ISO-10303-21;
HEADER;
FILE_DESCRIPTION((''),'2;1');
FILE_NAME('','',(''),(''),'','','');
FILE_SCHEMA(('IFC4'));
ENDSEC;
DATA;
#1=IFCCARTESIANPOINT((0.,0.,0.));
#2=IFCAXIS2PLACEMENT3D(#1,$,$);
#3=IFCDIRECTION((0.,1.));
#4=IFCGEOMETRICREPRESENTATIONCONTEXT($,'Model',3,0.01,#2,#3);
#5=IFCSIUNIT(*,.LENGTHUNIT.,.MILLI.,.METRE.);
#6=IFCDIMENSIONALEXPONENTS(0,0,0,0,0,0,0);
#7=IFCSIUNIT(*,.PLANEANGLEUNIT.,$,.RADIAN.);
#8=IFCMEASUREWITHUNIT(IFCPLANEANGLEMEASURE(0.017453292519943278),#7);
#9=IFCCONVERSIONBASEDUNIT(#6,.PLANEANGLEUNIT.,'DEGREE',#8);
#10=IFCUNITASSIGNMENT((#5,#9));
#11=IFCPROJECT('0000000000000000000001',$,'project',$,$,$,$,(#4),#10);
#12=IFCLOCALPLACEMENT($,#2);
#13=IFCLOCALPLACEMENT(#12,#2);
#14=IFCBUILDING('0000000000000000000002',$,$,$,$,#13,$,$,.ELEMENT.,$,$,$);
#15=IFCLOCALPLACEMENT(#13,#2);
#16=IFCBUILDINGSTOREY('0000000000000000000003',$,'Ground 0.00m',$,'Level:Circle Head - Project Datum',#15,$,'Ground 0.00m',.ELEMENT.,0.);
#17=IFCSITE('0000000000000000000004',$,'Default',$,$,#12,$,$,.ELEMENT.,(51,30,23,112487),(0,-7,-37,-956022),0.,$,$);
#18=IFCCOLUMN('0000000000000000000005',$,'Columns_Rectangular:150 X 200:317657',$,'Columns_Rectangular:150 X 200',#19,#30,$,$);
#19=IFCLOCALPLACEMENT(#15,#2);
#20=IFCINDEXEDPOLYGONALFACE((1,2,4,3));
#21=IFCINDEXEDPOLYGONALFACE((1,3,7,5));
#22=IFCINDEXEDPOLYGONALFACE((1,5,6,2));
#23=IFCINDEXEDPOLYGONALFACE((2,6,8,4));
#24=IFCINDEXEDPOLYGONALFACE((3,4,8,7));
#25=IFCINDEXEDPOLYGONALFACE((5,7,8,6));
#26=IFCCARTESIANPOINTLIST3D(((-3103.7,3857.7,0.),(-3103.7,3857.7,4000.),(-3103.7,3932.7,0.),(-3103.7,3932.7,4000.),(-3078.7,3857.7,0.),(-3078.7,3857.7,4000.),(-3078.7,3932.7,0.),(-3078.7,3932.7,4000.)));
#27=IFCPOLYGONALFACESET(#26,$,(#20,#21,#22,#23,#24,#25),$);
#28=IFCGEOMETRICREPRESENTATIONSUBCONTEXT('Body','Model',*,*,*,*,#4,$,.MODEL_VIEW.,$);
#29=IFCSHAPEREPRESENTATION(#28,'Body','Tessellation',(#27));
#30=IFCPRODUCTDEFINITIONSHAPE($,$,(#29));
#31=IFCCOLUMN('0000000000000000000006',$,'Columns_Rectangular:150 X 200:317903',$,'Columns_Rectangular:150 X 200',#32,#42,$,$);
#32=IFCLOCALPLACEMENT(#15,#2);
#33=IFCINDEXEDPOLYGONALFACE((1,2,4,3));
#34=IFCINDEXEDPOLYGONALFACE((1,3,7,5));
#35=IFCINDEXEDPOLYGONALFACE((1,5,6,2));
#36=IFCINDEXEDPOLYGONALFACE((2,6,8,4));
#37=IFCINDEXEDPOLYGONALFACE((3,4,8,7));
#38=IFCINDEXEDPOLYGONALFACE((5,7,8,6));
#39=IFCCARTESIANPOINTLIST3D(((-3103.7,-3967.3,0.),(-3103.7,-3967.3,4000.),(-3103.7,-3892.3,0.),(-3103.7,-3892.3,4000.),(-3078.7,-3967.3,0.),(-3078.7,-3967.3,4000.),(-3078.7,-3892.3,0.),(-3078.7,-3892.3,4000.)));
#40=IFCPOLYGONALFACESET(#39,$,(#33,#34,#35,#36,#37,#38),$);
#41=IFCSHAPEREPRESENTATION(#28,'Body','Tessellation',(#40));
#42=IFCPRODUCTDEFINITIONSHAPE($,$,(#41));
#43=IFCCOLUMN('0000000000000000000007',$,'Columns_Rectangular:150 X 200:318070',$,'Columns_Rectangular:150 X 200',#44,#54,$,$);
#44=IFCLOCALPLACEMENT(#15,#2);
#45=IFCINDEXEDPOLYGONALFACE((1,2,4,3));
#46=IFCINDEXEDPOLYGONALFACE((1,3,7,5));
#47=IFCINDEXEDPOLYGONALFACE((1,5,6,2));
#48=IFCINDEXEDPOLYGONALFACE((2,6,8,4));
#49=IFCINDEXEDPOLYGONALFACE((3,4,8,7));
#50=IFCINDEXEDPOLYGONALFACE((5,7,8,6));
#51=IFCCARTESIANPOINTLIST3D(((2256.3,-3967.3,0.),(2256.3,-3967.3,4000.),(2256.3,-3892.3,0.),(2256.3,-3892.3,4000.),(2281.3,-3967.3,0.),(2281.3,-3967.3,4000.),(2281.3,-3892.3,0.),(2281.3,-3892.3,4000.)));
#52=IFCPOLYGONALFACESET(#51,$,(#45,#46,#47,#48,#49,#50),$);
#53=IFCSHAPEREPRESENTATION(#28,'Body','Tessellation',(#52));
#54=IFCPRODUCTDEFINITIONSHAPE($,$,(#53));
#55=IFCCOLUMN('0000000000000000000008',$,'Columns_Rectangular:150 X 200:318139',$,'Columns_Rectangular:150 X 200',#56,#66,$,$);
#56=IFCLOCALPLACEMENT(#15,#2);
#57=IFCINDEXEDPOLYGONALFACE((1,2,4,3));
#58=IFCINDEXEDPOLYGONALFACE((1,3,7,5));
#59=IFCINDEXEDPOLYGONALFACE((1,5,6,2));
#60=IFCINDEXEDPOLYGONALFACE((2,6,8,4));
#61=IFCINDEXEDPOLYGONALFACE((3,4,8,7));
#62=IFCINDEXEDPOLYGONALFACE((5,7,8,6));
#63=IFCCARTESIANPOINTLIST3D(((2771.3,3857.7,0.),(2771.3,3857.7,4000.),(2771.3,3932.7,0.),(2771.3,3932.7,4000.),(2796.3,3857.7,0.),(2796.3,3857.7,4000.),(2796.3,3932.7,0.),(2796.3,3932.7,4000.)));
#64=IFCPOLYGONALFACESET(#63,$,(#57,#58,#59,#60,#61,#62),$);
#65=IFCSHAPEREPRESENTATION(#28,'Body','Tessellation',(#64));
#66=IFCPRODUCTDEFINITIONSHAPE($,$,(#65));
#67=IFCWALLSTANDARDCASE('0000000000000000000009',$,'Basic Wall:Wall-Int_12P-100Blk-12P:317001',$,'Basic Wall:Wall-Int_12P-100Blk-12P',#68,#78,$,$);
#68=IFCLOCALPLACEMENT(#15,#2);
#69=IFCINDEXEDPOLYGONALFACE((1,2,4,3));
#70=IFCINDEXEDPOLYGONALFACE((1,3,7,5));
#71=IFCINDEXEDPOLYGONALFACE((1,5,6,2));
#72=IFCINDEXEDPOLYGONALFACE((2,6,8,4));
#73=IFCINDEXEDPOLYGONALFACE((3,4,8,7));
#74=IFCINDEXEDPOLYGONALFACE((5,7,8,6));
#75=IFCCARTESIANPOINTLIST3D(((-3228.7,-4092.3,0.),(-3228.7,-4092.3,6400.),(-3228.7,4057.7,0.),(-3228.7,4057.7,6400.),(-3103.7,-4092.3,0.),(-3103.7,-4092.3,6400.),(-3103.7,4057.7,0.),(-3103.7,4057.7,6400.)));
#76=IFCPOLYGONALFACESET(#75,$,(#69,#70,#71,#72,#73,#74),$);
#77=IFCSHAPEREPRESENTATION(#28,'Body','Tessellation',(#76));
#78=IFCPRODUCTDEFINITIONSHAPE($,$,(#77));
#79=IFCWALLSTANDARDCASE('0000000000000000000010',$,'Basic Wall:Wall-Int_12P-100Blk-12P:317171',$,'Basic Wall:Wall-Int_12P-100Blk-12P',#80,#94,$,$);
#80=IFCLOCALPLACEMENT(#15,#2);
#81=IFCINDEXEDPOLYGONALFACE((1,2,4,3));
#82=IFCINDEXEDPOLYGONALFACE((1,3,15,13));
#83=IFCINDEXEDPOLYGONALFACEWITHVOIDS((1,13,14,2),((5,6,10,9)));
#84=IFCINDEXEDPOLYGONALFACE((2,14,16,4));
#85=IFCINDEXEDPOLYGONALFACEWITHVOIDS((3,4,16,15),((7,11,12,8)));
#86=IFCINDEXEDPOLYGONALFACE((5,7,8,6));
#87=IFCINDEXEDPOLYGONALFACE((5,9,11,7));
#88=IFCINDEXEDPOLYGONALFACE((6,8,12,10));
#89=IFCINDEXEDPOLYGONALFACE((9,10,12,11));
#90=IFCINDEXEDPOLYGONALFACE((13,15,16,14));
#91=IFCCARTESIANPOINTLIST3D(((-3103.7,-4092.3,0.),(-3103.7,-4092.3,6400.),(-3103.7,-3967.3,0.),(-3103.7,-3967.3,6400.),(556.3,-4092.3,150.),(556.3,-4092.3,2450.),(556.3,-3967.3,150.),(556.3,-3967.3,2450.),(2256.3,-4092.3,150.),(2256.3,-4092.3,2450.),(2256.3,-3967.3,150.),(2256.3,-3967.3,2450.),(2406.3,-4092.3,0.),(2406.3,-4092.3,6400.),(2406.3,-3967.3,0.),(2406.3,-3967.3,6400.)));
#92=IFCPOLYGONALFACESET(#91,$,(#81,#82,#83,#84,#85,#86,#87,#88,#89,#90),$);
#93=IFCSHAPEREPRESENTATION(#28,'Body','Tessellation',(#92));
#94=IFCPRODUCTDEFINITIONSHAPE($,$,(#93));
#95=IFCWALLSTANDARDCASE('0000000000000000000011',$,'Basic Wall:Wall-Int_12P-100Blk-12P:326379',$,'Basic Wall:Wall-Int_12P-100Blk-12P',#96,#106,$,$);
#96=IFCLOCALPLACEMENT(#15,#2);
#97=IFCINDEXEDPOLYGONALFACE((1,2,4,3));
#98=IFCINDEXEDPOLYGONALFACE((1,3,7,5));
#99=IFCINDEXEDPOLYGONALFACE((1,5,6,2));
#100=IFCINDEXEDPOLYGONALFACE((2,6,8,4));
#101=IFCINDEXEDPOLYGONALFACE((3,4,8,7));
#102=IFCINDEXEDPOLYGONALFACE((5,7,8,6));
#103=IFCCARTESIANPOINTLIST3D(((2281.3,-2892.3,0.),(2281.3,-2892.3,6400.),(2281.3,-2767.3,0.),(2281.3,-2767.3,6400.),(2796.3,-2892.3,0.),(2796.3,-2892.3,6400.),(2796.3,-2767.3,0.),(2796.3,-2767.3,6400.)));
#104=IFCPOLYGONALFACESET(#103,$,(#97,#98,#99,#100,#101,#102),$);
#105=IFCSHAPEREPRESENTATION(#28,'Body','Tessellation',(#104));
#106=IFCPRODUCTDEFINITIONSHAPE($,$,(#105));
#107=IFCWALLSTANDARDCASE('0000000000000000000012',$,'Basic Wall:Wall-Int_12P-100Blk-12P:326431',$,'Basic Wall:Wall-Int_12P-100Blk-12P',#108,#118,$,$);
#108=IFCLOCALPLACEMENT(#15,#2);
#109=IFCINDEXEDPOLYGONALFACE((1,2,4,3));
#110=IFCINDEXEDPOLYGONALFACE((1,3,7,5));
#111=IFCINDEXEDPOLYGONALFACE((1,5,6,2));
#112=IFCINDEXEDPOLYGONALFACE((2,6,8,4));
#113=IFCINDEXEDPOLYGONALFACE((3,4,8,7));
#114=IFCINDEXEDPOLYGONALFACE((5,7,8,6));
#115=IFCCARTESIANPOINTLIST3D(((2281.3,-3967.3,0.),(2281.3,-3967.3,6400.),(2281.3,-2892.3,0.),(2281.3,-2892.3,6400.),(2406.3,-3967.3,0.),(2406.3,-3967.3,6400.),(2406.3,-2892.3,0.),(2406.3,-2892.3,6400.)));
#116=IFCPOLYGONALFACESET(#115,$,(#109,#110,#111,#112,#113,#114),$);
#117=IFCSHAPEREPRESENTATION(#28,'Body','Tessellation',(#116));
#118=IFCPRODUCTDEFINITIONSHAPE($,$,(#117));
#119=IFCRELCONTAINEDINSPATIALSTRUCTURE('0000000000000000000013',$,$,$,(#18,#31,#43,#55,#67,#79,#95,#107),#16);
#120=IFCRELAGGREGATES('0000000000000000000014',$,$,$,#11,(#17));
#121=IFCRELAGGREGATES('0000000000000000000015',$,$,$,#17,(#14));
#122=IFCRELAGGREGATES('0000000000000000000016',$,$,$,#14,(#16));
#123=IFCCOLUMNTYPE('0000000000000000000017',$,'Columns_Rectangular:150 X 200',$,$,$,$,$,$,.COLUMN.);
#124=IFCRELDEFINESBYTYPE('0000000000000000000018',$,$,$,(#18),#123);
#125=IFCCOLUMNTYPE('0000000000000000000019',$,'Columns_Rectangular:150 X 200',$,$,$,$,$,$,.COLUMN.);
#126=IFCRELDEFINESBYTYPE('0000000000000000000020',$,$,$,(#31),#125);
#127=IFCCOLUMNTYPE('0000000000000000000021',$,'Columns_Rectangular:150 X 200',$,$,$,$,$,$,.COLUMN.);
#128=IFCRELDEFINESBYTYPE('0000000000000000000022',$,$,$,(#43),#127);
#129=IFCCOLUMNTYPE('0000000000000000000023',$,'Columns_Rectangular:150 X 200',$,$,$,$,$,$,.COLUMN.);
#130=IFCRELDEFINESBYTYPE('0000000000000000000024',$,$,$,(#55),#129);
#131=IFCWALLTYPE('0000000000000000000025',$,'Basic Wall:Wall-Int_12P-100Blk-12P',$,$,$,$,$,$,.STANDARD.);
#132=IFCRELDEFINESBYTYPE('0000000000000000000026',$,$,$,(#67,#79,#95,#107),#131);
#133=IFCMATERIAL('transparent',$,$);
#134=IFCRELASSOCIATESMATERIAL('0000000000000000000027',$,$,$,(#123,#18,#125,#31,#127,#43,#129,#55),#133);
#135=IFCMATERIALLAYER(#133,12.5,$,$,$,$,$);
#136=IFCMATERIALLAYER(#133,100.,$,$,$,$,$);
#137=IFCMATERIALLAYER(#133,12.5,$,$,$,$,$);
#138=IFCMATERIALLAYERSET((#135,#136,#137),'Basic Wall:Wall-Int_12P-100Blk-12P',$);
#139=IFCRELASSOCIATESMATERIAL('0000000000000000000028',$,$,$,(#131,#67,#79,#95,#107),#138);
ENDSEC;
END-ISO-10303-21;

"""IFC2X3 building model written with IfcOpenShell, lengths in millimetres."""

from ifc_helpers import new_model, entity, si_unit, converted_unit, direction, frame, frame_2d, origin, place, context, subcontext, project, spatial, rectangle, extrude, source, transform, mapped, material, layer, layer_set, layer_usage, type_object, type_shapes, element, save


model = new_model("IFC2X3")

# Units and contexts
model_context = context("Model", 3, precision=0.01, world=origin(), true_north=direction((0.0, 1.0)))
body_context = subcontext(model_context, "Body", "Model", "MODEL_VIEW")
ifc_project = project(units=[si_unit("LENGTHUNIT", "METRE", prefix="MILLI"), converted_unit("PLANEANGLEUNIT", "DEGREE", entity("IfcPlaneAngleMeasure", 0.017453292519943278), si_unit("PLANEANGLEUNIT", "RADIAN"), dimensions=[0, 0, 0, 0, 0, 0, 0])], contexts=[model_context])

# Site, building, storey
site_placement = place(None, origin())
site = spatial("IfcSite", under=ifc_project, at=site_placement, Name="Default", CompositionType="ELEMENT", RefLatitude=(51, 30, 23, 112487), RefLongitude=(0, -7, -37, -956022), RefElevation=0.0)
building_placement = place(site_placement, origin())
building = spatial("IfcBuilding", under=site, at=building_placement, CompositionType="ELEMENT")
storey_placement = place(building_placement, origin())
storey = spatial("IfcBuildingStorey", under=building, at=storey_placement, Name="Ground 0.00m", ObjectType="Level:Circle Head - Project Datum", LongName="Ground 0.00m", CompositionType="ELEMENT", Elevation=0.0)

# Columns
ifc_material_1 = material(Name="transparent")
column_type_1 = type_object("IfcColumnType", Name="Columns_Rectangular:150 X 200", PredefinedType="COLUMN", material=ifc_material_1)
shared_shape_1 = source(origin(), body_context, "Body", "SweptSolid", [
    extrude(rectangle(XDim=75.0, YDim=25.0, at=frame_2d((0.0, 0.0), x_axis=(1.0, 0.0))), frame((-3091.2, 3895.2, 0.0), z_axis=(0.0, 0.0, 1.0), x_axis=(0.0, 1.0, 0.0)), (0.0, 0.0, 1.0), 4000.0),
])
type_shapes(column_type_1, [shared_shape_1])
column_1_placement = place(storey_placement, origin())
element("IfcColumn", 1, at=column_1_placement, inside=storey, type_object=column_type_1, material=ifc_material_1, Name="Columns_Rectangular:150 X 200:317657", ObjectType="Columns_Rectangular:150 X 200", context=body_context, shape_type="MappedRepresentation", body=[
    mapped(shared_shape_1, transform((0.0, 0.0, 0.0), scale=1.0)),
])
column_type_2 = type_object("IfcColumnType", Name="Columns_Rectangular:150 X 200", PredefinedType="COLUMN", material=ifc_material_1)
shared_shape_2 = source(origin(), body_context, "Body", "SweptSolid", [
    extrude(rectangle(XDim=75.0, YDim=25.0, at=frame_2d((0.0, 0.0), x_axis=(1.0, 0.0))), frame((-3091.2, -3929.8, 0.0), z_axis=(0.0, 0.0, 1.0), x_axis=(0.0, -1.0, 0.0)), (0.0, 0.0, 1.0), 4000.0),
])
type_shapes(column_type_2, [shared_shape_2])
column_2_placement = place(storey_placement, origin())
element("IfcColumn", 2, at=column_2_placement, inside=storey, type_object=column_type_2, material=ifc_material_1, Name="Columns_Rectangular:150 X 200:317903", ObjectType="Columns_Rectangular:150 X 200", context=body_context, shape_type="MappedRepresentation", body=[
    mapped(shared_shape_2, transform((0.0, 0.0, 0.0), scale=1.0)),
])
column_type_3 = type_object("IfcColumnType", Name="Columns_Rectangular:150 X 200", PredefinedType="COLUMN", material=ifc_material_1)
shared_shape_3 = source(origin(), body_context, "Body", "SweptSolid", [
    extrude(rectangle(XDim=25.0, YDim=75.0, at=frame_2d((0.0, 0.0), x_axis=(1.0, 0.0))), frame((2268.8, -3929.8, 0.0)), (0.0, 0.0, 1.0), 4000.0),
])
type_shapes(column_type_3, [shared_shape_3])
column_3_placement = place(storey_placement, origin())
element("IfcColumn", 3, at=column_3_placement, inside=storey, type_object=column_type_3, material=ifc_material_1, Name="Columns_Rectangular:150 X 200:318070", ObjectType="Columns_Rectangular:150 X 200", context=body_context, shape_type="MappedRepresentation", body=[
    mapped(shared_shape_3, transform((0.0, 0.0, 0.0), scale=1.0)),
])
column_type_4 = type_object("IfcColumnType", Name="Columns_Rectangular:150 X 200", PredefinedType="COLUMN", material=ifc_material_1)
shared_shape_4 = source(origin(), body_context, "Body", "SweptSolid", [
    extrude(rectangle(XDim=25.0, YDim=75.0, at=frame_2d((0.0, 0.0), x_axis=(1.0, 0.0))), frame((2783.8, 3895.2, 0.0)), (0.0, 0.0, 1.0), 4000.0),
])
type_shapes(column_type_4, [shared_shape_4])
column_4_placement = place(storey_placement, origin())
element("IfcColumn", 4, at=column_4_placement, inside=storey, type_object=column_type_4, material=ifc_material_1, Name="Columns_Rectangular:150 X 200:318139", ObjectType="Columns_Rectangular:150 X 200", context=body_context, shape_type="MappedRepresentation", body=[
    mapped(shared_shape_4, transform((0.0, 0.0, 0.0), scale=1.0)),
])

# Wall
ifc_layer_1 = layer(ifc_material_1, 12.5)
ifc_layer_2 = layer(ifc_material_1, 100.0)
ifc_layer_3 = layer(ifc_material_1, 12.5)
ifc_layer_set = layer_set([ifc_layer_1, ifc_layer_2, ifc_layer_3], Name="Basic Wall:Wall-Int_12P-100Blk-12P")
ifc_layer_usage_1 = layer_usage(ifc_layer_set, "AXIS2", "NEGATIVE", 62.5)
wall_type = type_object("IfcWallType", Name="Basic Wall:Wall-Int_12P-100Blk-12P", PredefinedType="STANDARD", material=ifc_layer_set)
wall_1_placement = place(storey_placement, frame((-3166.2, -4092.3, 0.0), z_axis=(0.0, 0.0, 1.0), x_axis=(0.0, 1.0, 0.0)))
element("IfcWallStandardCase", 5, at=wall_1_placement, inside=storey, type_object=wall_type, material=ifc_layer_usage_1, Name="Basic Wall:Wall-Int_12P-100Blk-12P:317001", ObjectType="Basic Wall:Wall-Int_12P-100Blk-12P", context=body_context, shape_type="SweptSolid", body=[
    extrude(rectangle(XDim=8150.0, YDim=125.0, at=frame_2d((4075.0, 0.0), x_axis=(-1.0, 0.0))), origin(), (0.0, 0.0, 1.0), 6400.0),
])

# Wall, opening
ifc_layer_usage_2 = layer_usage(ifc_layer_set, "AXIS2", "NEGATIVE", 62.5)
wall_2_placement = place(storey_placement, frame((2406.3, -4029.8, 0.0), z_axis=(0.0, 0.0, 1.0), x_axis=(-1.0, 0.0, 0.0)))
wall_2 = element("IfcWallStandardCase", 6, at=wall_2_placement, inside=storey, type_object=wall_type, material=ifc_layer_usage_2, Name="Basic Wall:Wall-Int_12P-100Blk-12P:317171", ObjectType="Basic Wall:Wall-Int_12P-100Blk-12P", context=body_context, shape_type="SweptSolid", body=[
    extrude(rectangle(XDim=5510.0, YDim=125.0, at=frame_2d((2755.0, 0.0), x_axis=(-1.0, 0.0))), origin(), (0.0, 0.0, 1.0), 6400.0),
])
opening_placement = place(wall_2_placement, frame((1850.0, 62.5, 150.0)))
element("IfcOpeningElement", 7, at=opening_placement, cuts=wall_2, ObjectType="Opening", context=body_context, shape_type="SweptSolid", body=[
    extrude(rectangle(XDim=2300.0, YDim=1700.0, at=frame_2d((1150.0, 850.0), x_axis=(1.0, 0.0))), frame((0.0, 0.0, 0.0), z_axis=(0.0, -1.0, 0.0), x_axis=(0.0, 0.0, 1.0)), (0.0, 0.0, 1.0), 125.0),
])

# Walls
ifc_layer_usage_3 = layer_usage(ifc_layer_set, "AXIS2", "NEGATIVE", 62.5)
wall_3_placement = place(storey_placement, frame((2796.3, -2829.8, 0.0), z_axis=(0.0, 0.0, 1.0), x_axis=(-1.0, 0.0, 0.0)))
element("IfcWallStandardCase", 8, at=wall_3_placement, inside=storey, type_object=wall_type, material=ifc_layer_usage_3, Name="Basic Wall:Wall-Int_12P-100Blk-12P:326379", ObjectType="Basic Wall:Wall-Int_12P-100Blk-12P", context=body_context, shape_type="SweptSolid", body=[
    extrude(rectangle(XDim=515.0, YDim=125.0, at=frame_2d((257.5, 0.0), x_axis=(-1.0, 0.0))), origin(), (0.0, 0.0, 1.0), 6400.0),
])
ifc_layer_usage_4 = layer_usage(ifc_layer_set, "AXIS2", "NEGATIVE", 62.5)
wall_4_placement = place(storey_placement, frame((2343.8, -2892.3, 0.0), z_axis=(0.0, 0.0, 1.0), x_axis=(0.0, -1.0, 0.0)))
element("IfcWallStandardCase", 9, at=wall_4_placement, inside=storey, type_object=wall_type, material=ifc_layer_usage_4, Name="Basic Wall:Wall-Int_12P-100Blk-12P:326431", ObjectType="Basic Wall:Wall-Int_12P-100Blk-12P", context=body_context, shape_type="SweptSolid", body=[
    extrude(rectangle(XDim=1075.0, YDim=125.0, at=frame_2d((537.5, 0.0), x_axis=(-1.0, 0.0))), origin(), (0.0, 0.0, 1.0), 6400.0),
])

save(model, "model.ifc")
